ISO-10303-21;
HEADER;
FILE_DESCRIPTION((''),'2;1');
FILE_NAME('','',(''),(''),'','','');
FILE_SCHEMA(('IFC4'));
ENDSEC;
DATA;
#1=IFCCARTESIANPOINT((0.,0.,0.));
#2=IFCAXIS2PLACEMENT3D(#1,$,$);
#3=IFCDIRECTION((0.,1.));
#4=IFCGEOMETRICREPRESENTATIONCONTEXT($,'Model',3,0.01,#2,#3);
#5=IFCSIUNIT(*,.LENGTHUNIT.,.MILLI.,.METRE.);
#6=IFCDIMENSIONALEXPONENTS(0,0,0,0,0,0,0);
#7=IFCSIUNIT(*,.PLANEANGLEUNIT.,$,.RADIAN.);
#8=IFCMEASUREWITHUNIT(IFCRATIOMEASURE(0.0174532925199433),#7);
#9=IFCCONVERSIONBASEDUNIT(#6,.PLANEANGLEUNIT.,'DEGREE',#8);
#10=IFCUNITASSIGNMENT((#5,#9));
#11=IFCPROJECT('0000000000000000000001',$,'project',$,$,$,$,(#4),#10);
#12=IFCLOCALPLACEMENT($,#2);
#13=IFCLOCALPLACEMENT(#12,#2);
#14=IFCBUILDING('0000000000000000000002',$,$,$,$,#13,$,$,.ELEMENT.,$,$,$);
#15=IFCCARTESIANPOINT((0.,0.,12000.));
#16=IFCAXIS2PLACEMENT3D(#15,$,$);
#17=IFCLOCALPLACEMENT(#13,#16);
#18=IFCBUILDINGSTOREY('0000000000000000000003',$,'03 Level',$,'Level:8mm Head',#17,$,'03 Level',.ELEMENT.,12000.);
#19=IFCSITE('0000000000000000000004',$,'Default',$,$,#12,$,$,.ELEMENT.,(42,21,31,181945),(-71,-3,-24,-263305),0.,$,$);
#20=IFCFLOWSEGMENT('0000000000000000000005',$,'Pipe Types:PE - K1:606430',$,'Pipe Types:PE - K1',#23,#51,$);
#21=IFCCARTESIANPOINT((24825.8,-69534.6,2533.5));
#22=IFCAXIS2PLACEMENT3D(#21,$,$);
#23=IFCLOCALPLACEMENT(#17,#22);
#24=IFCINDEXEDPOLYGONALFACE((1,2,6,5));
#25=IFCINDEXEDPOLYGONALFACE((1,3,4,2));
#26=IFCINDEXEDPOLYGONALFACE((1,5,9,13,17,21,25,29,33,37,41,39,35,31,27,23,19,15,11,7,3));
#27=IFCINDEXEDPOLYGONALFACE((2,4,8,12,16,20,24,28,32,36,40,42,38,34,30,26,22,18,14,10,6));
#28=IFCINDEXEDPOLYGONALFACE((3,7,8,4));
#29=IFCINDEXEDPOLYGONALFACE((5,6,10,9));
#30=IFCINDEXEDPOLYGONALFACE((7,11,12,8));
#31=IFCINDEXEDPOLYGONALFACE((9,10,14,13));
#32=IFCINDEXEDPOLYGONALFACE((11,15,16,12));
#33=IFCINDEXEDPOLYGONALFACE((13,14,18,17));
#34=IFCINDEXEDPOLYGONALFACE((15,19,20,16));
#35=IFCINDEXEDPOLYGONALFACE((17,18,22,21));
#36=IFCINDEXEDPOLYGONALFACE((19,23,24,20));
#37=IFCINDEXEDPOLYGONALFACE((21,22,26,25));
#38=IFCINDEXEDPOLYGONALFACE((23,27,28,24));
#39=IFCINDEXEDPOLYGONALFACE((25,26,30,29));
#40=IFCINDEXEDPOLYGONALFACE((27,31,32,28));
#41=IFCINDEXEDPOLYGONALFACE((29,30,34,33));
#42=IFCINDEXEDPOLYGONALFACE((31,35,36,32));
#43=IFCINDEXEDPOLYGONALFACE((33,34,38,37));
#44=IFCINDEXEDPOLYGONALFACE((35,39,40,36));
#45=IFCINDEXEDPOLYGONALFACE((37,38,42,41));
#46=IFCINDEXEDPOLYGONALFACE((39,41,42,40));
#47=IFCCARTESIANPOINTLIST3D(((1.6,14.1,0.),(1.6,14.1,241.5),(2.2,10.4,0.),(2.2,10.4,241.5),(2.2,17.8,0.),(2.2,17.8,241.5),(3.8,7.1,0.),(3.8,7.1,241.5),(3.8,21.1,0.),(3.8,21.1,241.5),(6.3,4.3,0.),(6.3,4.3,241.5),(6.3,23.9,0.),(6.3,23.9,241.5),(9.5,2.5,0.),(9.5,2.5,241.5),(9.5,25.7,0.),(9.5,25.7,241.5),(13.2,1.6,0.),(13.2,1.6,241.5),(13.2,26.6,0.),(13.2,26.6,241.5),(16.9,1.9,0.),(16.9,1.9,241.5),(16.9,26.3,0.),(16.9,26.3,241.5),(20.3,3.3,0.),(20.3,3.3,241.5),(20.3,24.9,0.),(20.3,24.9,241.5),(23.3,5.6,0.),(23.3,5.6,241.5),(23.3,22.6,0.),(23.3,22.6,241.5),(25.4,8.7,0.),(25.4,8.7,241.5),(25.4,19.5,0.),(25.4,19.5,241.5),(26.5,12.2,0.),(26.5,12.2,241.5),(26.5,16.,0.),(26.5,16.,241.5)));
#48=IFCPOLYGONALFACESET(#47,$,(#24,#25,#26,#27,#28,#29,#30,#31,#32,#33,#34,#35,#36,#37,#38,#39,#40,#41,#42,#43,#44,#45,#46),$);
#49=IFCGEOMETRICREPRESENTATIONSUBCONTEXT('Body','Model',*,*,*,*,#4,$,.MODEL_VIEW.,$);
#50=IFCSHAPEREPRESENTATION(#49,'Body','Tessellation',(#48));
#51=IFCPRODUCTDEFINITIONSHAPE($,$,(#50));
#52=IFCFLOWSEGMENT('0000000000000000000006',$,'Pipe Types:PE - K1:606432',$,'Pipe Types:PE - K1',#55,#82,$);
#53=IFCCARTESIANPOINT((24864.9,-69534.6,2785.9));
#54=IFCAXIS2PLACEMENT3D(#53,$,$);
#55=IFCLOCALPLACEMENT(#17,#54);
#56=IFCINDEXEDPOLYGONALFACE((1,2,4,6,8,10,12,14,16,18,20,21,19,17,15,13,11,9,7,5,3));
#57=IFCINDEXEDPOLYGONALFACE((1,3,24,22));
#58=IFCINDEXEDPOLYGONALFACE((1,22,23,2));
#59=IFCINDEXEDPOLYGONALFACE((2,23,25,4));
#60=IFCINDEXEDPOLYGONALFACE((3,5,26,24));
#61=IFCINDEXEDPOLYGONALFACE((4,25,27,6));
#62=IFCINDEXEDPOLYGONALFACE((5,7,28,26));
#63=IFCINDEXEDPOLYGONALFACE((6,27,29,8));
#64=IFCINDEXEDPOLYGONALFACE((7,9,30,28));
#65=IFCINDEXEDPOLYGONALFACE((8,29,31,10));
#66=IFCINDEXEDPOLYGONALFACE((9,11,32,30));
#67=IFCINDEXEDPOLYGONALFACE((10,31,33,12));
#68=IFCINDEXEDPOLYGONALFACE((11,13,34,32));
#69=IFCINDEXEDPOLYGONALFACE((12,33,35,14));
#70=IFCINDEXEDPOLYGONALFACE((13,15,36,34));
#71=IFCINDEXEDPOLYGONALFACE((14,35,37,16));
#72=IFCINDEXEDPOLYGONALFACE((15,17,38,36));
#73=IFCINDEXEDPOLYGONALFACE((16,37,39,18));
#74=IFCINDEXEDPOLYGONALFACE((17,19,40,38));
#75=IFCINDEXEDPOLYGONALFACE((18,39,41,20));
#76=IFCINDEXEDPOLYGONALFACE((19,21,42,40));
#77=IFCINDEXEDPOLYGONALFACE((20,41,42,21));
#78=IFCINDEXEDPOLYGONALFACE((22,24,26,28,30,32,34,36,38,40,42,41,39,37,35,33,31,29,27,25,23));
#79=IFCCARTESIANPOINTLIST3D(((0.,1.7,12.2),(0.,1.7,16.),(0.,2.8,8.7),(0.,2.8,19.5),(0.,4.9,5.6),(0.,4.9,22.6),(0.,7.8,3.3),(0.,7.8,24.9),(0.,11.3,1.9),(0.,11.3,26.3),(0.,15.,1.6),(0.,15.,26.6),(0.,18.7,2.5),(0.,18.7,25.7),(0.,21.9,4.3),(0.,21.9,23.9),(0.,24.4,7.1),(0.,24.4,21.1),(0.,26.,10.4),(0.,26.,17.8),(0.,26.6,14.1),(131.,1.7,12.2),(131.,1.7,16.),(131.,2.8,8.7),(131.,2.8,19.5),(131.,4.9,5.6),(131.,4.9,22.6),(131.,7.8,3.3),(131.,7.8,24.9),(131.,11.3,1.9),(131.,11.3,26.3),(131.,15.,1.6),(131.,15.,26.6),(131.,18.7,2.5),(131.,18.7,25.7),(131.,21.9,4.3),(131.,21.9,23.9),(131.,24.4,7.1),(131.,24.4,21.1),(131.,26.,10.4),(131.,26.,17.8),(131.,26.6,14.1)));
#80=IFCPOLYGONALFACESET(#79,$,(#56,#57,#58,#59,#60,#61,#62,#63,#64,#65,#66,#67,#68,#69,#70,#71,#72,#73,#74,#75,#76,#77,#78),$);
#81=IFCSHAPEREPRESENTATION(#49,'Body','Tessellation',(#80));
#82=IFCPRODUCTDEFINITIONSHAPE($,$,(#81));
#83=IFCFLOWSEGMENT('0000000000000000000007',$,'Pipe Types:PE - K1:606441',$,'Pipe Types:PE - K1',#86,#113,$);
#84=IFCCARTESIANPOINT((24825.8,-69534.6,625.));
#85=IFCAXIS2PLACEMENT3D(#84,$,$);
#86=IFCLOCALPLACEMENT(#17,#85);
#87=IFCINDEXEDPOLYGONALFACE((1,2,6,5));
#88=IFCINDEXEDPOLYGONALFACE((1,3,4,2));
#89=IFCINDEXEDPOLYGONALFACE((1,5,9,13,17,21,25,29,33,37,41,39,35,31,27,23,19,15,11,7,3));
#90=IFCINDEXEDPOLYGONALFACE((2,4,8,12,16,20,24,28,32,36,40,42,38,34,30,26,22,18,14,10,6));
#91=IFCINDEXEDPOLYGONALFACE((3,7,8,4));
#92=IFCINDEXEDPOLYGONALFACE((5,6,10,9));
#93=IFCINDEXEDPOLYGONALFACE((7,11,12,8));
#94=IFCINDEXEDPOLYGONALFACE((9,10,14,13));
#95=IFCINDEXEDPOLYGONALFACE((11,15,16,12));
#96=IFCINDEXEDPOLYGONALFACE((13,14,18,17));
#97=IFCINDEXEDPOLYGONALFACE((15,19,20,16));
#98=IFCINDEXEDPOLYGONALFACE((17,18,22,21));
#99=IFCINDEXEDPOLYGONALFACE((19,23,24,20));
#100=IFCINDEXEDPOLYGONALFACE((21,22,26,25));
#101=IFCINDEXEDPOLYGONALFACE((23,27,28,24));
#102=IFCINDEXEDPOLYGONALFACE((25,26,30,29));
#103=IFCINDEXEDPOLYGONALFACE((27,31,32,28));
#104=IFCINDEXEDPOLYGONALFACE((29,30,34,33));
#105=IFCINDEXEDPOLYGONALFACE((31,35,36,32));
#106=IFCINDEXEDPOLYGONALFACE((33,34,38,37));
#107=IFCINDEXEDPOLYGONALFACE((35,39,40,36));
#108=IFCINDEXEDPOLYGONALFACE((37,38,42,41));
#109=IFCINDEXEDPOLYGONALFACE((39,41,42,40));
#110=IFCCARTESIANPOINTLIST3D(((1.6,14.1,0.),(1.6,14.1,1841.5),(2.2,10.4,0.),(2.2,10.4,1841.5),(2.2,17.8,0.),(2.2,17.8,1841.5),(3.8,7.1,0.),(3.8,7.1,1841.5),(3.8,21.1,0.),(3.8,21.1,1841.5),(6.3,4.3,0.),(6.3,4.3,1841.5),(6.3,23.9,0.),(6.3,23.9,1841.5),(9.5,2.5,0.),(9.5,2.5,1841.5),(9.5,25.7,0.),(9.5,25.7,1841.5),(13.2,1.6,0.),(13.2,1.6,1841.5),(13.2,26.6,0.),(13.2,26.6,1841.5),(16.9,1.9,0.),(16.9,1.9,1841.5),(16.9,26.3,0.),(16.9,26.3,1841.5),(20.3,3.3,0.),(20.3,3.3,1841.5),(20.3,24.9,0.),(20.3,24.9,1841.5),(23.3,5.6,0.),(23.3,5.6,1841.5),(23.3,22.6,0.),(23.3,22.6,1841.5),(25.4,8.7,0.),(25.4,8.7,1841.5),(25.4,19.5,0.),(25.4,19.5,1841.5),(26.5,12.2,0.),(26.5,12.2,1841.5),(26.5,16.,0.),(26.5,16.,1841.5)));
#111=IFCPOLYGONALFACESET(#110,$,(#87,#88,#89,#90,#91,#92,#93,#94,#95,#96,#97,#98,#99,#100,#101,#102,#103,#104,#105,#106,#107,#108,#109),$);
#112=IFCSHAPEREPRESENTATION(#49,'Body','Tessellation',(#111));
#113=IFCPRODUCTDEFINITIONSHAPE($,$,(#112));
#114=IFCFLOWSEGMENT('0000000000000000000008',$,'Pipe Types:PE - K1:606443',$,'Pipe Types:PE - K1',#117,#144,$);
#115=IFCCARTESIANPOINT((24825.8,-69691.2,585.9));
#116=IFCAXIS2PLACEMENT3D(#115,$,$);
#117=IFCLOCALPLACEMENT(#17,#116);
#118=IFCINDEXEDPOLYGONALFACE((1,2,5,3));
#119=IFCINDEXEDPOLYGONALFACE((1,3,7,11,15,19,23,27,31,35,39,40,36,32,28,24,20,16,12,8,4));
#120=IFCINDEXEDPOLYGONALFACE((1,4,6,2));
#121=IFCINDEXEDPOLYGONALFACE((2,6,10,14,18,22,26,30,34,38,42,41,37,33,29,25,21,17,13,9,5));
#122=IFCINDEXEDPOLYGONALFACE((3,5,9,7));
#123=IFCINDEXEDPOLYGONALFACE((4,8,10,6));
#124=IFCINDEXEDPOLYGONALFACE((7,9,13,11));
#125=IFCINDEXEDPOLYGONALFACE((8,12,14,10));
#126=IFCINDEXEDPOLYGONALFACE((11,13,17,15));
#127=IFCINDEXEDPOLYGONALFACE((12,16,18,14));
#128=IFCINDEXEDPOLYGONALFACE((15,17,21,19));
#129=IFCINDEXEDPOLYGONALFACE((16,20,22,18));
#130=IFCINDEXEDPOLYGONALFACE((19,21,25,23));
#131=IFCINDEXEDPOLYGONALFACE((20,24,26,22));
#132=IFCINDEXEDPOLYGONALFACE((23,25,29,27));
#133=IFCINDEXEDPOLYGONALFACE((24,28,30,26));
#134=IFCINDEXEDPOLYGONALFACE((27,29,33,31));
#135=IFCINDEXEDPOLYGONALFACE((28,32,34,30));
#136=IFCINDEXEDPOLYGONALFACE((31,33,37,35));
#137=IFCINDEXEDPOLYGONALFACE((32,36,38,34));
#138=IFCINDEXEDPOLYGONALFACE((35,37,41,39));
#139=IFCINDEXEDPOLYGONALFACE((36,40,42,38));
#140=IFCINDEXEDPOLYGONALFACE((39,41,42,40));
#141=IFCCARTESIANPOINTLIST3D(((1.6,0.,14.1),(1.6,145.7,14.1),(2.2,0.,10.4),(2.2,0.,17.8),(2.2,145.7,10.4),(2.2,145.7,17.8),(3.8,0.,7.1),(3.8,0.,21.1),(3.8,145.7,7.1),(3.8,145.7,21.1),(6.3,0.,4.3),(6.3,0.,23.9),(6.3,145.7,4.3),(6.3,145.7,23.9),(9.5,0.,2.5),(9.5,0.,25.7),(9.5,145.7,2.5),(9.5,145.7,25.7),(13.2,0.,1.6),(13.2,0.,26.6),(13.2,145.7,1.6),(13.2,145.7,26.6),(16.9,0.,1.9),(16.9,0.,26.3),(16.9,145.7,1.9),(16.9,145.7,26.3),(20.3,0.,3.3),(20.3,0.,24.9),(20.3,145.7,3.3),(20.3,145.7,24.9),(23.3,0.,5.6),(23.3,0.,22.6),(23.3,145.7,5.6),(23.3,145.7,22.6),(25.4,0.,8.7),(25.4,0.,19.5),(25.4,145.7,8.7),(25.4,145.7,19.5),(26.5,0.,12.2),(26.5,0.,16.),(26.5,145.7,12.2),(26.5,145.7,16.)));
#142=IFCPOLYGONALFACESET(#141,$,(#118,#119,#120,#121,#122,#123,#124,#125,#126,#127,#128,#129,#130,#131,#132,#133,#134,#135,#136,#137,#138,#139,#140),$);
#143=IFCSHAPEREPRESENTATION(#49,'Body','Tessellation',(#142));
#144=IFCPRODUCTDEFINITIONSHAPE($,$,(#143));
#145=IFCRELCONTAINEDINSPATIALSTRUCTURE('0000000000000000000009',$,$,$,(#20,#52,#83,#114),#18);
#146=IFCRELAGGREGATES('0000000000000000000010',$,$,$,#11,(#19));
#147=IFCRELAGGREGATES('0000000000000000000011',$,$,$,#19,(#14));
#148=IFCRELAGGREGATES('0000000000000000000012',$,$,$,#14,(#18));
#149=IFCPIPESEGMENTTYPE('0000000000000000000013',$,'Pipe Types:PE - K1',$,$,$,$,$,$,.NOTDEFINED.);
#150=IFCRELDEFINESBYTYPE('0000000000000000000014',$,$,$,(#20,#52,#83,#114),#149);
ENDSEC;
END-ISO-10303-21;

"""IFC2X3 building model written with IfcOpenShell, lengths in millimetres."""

from ifc_helpers import new_model, entity, si_unit, converted_unit, direction, frame, frame_2d, origin, origin_2d_with_axis, place, context, subcontext, project, spatial, circle, extrude, type_object, element, save


model = new_model("IFC2X3")

# Units and contexts
model_context = context("Model", 3, precision=0.01, world=origin(), true_north=direction((0.0, 1.0)))
body_context = subcontext(model_context, "Body", "Model", "MODEL_VIEW")
ifc_project = project(units=[si_unit("LENGTHUNIT", "METRE", prefix="MILLI"), converted_unit("PLANEANGLEUNIT", "DEGREE", entity("IfcRatioMeasure", 0.0174532925199433), si_unit("PLANEANGLEUNIT", "RADIAN"), dimensions=[0, 0, 0, 0, 0, 0, 0])], contexts=[model_context])

# Site, building, storey
site_placement = place(None, origin())
site = spatial("IfcSite", under=ifc_project, at=site_placement, Name="Default", CompositionType="ELEMENT", RefLatitude=(42, 21, 31, 181945), RefLongitude=(-71, -3, -24, -263305), RefElevation=0.0)
building_placement = place(site_placement, origin())
building = spatial("IfcBuilding", under=site, at=building_placement, CompositionType="ELEMENT")
storey_placement = place(building_placement, frame((0.0, 0.0, 12000.0)))
storey = spatial("IfcBuildingStorey", under=building, at=storey_placement, Name="03 Level", ObjectType="Level:8mm Head", LongName="03 Level", CompositionType="ELEMENT", Elevation=12000.0)

# Flow segments
pipe_segment_type = type_object("IfcPipeSegmentType", Name="Pipe Types:PE - K1", PredefinedType="NOTDEFINED")
flow_segment_1_placement = place(storey_placement, frame((24825.8, -69534.6, 2533.5)))
element("IfcFlowSegment", 1, at=flow_segment_1_placement, inside=storey, type_object=pipe_segment_type, Name="Pipe Types:PE - K1:606430", ObjectType="Pipe Types:PE - K1", context=body_context, shape_type="SweptSolid", body=[
    extrude(circle(Radius=12.5, at=frame_2d((0.0, 0.0), x_axis=(1.0, 0.0))), frame((14.1, 14.1, 0.0), z_axis=(0.0, 0.0, 1.0), x_axis=(-1.0, 0.0, 0.0)), (0.0, 0.0, 1.0), 241.5),
])
flow_segment_2_placement = place(storey_placement, frame((24864.9, -69534.6, 2785.9)))
element("IfcFlowSegment", 2, at=flow_segment_2_placement, inside=storey, type_object=pipe_segment_type, Name="Pipe Types:PE - K1:606432", ObjectType="Pipe Types:PE - K1", context=body_context, shape_type="SweptSolid", body=[
    extrude(circle(Radius=12.5, at=origin_2d_with_axis()), frame((0.0, 14.1, 14.1), z_axis=(1.0, 0.0, 0.0), x_axis=(0.0, 1.0, 0.0)), (0.0, 0.0, 1.0), 131.0),
])
flow_segment_3_placement = place(storey_placement, frame((24825.8, -69534.6, 625.0)))
element("IfcFlowSegment", 3, at=flow_segment_3_placement, inside=storey, type_object=pipe_segment_type, Name="Pipe Types:PE - K1:606441", ObjectType="Pipe Types:PE - K1", context=body_context, shape_type="SweptSolid", body=[
    extrude(circle(Radius=12.5, at=origin_2d_with_axis()), frame((14.1, 14.1, 0.0), z_axis=(0.0, 0.0, 1.0), x_axis=(-1.0, 0.0, 0.0)), (0.0, 0.0, 1.0), 1841.5),
])
flow_segment_4_placement = place(storey_placement, frame((24825.8, -69691.2, 585.9)))
element("IfcFlowSegment", 4, at=flow_segment_4_placement, inside=storey, type_object=pipe_segment_type, Name="Pipe Types:PE - K1:606443", ObjectType="Pipe Types:PE - K1", context=body_context, shape_type="SweptSolid", body=[
    extrude(circle(Radius=12.5, at=frame_2d((0.0, 0.0), x_axis=(1.0, 0.0))), frame((14.1, 0.0, 14.1), z_axis=(0.0, 1.0, 0.0), x_axis=(-1.0, 0.0, 0.0)), (0.0, 0.0, 1.0), 145.7),
])

save(model, "model.ifc")
